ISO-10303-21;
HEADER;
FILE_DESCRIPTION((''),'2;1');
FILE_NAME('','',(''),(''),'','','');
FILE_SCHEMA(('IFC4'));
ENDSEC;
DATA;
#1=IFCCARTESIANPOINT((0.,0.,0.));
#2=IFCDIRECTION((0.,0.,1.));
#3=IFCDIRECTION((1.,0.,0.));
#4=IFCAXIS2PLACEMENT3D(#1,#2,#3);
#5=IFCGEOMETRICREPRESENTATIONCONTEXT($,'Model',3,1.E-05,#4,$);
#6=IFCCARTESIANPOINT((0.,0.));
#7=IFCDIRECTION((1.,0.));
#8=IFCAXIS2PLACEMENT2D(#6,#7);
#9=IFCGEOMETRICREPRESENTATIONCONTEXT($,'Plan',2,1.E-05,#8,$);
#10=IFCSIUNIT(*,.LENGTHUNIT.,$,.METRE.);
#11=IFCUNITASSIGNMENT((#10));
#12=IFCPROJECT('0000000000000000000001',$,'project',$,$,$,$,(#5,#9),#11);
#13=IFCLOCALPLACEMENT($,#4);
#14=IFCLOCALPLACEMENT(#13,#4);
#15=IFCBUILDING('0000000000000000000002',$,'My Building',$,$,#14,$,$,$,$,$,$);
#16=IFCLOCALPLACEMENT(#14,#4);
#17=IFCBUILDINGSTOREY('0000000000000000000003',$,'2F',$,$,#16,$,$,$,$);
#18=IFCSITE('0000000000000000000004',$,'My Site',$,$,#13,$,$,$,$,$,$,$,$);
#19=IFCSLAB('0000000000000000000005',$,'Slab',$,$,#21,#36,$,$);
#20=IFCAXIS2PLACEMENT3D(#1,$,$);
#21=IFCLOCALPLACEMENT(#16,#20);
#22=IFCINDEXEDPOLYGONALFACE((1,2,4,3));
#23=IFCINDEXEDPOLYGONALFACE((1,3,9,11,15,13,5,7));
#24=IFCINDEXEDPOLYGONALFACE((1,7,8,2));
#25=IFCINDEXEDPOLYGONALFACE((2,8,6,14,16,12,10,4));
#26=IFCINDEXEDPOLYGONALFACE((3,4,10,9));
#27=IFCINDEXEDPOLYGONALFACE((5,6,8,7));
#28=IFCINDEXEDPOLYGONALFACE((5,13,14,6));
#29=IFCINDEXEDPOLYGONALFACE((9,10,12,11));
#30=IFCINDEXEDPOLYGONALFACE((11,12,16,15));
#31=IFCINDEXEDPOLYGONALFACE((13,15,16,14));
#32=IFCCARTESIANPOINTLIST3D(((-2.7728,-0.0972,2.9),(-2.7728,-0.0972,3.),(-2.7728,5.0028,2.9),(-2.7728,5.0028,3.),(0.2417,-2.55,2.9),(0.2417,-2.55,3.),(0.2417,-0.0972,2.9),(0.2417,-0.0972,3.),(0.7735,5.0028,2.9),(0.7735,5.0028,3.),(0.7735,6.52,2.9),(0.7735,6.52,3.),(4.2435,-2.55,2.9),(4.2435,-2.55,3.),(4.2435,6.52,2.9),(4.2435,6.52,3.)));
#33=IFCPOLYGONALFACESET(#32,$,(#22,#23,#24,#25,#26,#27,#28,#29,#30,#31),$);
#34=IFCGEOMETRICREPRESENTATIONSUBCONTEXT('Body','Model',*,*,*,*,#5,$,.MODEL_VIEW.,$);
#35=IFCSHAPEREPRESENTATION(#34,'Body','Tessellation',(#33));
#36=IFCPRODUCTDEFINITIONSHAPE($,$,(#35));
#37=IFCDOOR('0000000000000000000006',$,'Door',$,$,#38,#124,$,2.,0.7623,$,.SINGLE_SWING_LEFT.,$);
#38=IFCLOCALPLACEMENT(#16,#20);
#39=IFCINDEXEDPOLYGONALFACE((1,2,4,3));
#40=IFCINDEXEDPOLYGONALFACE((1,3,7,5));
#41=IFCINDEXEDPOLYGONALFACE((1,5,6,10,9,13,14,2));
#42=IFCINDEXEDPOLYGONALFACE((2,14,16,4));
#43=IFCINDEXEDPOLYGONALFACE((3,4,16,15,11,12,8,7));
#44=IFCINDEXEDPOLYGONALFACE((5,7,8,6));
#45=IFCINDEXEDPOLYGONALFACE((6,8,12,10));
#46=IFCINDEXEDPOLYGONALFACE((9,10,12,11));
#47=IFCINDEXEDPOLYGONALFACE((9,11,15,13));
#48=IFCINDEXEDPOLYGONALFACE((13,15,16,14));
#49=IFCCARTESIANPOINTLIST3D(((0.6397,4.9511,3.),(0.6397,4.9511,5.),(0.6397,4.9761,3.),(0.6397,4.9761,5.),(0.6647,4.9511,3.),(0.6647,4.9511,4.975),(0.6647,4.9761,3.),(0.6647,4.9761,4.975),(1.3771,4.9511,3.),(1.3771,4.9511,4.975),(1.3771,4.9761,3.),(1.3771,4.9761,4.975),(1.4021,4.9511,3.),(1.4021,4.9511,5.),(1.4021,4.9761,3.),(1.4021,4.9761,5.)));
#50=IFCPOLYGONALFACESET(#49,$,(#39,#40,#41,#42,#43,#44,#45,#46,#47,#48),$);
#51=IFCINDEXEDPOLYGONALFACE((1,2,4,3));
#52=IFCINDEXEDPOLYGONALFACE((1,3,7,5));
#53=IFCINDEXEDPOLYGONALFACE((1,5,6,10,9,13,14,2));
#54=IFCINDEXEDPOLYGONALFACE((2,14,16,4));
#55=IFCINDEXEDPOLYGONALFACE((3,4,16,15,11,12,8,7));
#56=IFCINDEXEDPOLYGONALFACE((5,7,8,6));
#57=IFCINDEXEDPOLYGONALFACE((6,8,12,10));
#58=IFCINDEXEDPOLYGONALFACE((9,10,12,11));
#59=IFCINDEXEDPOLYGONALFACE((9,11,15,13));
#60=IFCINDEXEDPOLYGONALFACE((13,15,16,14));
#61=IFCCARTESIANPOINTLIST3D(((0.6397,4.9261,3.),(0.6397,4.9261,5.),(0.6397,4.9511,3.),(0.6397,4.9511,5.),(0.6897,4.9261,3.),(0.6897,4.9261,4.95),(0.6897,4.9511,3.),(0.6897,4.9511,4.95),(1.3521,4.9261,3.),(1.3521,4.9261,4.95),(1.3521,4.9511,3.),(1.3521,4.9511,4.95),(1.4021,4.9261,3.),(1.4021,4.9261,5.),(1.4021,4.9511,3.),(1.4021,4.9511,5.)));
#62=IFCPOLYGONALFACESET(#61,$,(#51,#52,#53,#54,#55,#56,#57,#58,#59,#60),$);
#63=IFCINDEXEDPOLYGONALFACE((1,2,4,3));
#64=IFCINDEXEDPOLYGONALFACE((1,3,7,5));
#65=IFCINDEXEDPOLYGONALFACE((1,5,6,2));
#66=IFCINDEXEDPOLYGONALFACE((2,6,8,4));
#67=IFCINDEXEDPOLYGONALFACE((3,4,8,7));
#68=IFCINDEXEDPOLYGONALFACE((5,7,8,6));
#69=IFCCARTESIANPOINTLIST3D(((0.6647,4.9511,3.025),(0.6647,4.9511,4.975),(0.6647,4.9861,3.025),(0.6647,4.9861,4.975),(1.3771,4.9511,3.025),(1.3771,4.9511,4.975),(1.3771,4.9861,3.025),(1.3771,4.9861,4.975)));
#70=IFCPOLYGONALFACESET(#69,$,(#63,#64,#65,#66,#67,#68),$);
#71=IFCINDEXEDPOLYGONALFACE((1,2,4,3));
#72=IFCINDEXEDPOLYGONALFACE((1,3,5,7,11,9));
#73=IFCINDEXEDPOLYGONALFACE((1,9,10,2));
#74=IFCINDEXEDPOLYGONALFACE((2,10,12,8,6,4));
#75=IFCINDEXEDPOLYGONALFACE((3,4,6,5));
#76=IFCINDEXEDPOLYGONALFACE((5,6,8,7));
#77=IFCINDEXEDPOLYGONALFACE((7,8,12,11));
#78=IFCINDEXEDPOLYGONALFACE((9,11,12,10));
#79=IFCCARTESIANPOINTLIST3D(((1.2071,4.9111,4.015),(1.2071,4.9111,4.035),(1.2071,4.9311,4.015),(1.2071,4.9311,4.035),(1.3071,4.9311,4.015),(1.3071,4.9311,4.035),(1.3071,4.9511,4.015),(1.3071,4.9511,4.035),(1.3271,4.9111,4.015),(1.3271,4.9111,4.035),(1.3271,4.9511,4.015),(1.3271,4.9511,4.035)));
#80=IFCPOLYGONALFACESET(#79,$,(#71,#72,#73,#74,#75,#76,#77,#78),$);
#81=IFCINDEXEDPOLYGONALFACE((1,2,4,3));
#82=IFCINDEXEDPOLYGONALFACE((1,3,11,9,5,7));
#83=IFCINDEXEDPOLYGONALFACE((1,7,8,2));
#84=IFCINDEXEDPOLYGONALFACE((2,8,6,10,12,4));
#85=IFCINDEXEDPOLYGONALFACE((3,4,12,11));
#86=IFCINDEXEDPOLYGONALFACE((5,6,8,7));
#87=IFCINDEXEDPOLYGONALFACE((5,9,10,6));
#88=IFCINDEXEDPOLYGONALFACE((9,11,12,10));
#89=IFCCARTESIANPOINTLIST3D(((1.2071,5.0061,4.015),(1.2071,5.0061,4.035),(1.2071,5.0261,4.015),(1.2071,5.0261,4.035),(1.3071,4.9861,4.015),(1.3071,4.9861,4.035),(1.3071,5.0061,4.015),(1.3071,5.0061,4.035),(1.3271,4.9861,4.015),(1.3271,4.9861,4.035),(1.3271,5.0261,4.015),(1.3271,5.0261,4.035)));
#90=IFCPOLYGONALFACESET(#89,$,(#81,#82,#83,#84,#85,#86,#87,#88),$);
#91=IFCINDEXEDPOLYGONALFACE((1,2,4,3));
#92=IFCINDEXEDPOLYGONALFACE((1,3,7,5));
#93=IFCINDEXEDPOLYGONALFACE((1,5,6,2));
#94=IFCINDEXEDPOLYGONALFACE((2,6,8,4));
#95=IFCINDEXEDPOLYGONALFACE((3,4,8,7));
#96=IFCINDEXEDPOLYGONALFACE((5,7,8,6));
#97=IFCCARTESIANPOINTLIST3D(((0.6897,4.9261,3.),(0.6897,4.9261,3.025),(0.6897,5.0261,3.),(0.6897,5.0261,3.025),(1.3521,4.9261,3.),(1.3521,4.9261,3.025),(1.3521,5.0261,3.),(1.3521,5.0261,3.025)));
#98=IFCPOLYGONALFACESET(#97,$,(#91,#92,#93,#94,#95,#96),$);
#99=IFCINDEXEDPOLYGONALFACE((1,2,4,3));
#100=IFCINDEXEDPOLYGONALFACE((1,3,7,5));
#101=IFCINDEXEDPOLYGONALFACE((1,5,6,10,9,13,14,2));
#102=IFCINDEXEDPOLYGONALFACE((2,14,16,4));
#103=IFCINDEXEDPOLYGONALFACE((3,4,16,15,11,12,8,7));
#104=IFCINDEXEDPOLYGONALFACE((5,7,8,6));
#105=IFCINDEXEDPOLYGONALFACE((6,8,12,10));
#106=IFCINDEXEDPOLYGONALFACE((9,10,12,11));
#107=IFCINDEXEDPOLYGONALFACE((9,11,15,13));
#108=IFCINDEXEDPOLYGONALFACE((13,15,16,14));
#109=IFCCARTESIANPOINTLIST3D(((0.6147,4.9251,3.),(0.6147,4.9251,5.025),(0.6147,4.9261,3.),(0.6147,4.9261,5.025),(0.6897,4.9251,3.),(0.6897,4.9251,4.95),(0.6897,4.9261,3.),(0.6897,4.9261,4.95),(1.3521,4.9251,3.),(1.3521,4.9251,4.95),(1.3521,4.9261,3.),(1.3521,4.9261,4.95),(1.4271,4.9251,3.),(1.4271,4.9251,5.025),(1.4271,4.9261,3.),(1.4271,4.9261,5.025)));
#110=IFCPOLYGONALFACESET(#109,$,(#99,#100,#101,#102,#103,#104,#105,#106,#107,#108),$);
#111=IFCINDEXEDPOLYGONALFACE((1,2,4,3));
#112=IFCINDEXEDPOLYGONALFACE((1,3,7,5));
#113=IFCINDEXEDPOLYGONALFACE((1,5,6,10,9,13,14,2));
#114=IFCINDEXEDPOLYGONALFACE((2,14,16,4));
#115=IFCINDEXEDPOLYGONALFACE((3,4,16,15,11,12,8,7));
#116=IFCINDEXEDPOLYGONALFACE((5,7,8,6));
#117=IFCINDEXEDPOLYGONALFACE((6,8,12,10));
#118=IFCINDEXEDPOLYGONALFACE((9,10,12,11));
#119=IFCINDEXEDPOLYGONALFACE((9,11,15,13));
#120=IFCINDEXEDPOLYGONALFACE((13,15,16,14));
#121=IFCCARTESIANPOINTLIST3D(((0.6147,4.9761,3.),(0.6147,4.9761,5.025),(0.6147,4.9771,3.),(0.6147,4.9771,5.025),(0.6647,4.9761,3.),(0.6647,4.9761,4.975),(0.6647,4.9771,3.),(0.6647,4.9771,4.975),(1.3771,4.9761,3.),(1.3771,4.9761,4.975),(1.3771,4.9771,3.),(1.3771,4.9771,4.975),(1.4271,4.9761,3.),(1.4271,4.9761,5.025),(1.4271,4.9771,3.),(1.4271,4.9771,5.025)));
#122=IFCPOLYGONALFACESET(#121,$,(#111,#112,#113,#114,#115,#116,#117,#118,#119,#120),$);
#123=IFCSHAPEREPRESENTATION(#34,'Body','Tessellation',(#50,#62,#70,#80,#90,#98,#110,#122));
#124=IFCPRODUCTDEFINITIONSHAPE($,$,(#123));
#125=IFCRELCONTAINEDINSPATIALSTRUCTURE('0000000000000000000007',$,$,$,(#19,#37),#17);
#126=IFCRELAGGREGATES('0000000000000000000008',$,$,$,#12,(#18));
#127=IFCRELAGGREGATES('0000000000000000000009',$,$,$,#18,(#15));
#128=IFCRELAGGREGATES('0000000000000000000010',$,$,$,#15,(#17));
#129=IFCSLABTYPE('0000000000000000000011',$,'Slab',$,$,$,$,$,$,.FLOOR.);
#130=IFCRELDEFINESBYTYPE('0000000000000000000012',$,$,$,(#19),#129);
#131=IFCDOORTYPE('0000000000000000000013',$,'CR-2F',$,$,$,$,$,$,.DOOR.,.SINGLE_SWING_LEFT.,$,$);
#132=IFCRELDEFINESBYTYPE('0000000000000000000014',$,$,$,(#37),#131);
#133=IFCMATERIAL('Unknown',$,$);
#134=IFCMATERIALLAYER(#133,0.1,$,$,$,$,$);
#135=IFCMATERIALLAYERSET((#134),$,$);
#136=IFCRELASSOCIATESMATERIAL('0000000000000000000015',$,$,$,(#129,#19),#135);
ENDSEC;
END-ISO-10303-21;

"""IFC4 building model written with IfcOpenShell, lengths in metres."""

from ifc_helpers import new_model, entity, si_unit, frame, origin_with_axes, origin_2d_with_axis, place, context, subcontext, project, spatial, line, indexed_curve, outline, extrude, shape, source, transform, mapped, material, layer, layer_set, layer_usage, type_object, type_shapes, element, save


model = new_model("IFC4")

# Units and contexts
model_context = context("Model", 3, precision=1e-05, world=origin_with_axes())
plan_context = context("Plan", 2, precision=1e-05, world=origin_2d_with_axis())
body_context_1 = subcontext(model_context, "Body", "Model", "MODEL_VIEW")
body_context_2 = subcontext(plan_context, "Body", "Plan", "PLAN_VIEW")
ifc_project = project(units=[si_unit("LENGTHUNIT", "METRE")], contexts=[model_context, plan_context])

# Site, building, storey
site_placement = place(None, origin_with_axes())
site = spatial("IfcSite", under=ifc_project, at=site_placement, Name="My Site")
building_placement = place(site_placement, origin_with_axes())
building = spatial("IfcBuilding", under=site, at=building_placement, Name="My Building")
storey_placement = place(building_placement, origin_with_axes())
storey = spatial("IfcBuildingStorey", under=building, at=storey_placement, Name="2F")

# Slab
ifc_material = material(Name="Unknown")
ifc_layer = layer(ifc_material, 0.1)
ifc_layer_set = layer_set([ifc_layer])
ifc_layer_usage = layer_usage(ifc_layer_set, "AXIS3", "POSITIVE", -0.1)
slab_type = type_object("IfcSlabType", Name="Slab", PredefinedType="FLOOR", material=ifc_layer_set)
slab_placement = place(storey_placement, frame((4.2435, -2.55, 3.0), z_axis=(0.0, 0.0, 1.0), x_axis=(1.0, 0.0, 0.0)))
element("IfcSlab", 1, at=slab_placement, inside=storey, type_object=slab_type, material=ifc_layer_usage, Name="Slab", context=body_context_1, shape_type="SweptSolid", body=[
    extrude(outline(indexed_curve([(0.0, 0.0), (0.0, 9.07), (-3.47, 9.07), (-3.47, 7.5528), (-7.0163, 7.5528), (-7.0163, 2.4528), (-4.0018, 2.4528), (-4.0018, 0.0), (0.0, 0.0)])), frame((0.0, 0.0, -0.1), z_axis=(0.0, 0.0, 1.0), x_axis=(1.0, 0.0, 0.0)), (0.0, 0.0, 1.0), 0.1),
])

# Door
door_type_1 = type_object("IfcDoorType", Name="CR-2F", OperationType="SINGLE_SWING_LEFT", PredefinedType="DOOR")
shared_shape_1 = source(origin_with_axes(), body_context_1, "Body", "SweptSolid", [
    extrude(outline(indexed_curve([(0.0, 0.0), (0.0, 2.0), (0.7623, 2.0), (0.7623, 0.0), (0.7373, 0.0), (0.7373, 1.975), (0.025, 1.975), (0.025, 0.0)], segments=[line(1, 2, 3, 4, 5, 6, 7, 8, 1)])), frame((0.0, 0.025, 0.0), z_axis=(0.0, -1.0, 0.0), x_axis=(1.0, 0.0, 0.0)), (0.0, 0.0, -1.0), 0.025),
    extrude(outline(indexed_curve([(0.0, 0.0), (0.0, 2.0), (0.7623, 2.0), (0.7623, 0.0), (0.7123, 0.0), (0.7123, 1.95), (0.05, 1.95), (0.05, 0.0)], segments=[line(1, 2, 3, 4, 5, 6, 7, 8, 1)])), frame((0.0, 0.0, 0.0), z_axis=(0.0, -1.0, 0.0), x_axis=(1.0, 0.0, 0.0)), (0.0, 0.0, -1.0), 0.025),
    extrude(outline(indexed_curve([(0.0, 0.0), (0.7123, 0.0), (0.7123, 0.035), (0.0, 0.035)], segments=[line(1, 2, 3, 4, 1)])), frame((0.025, 0.025, 0.025), z_axis=(0.0, 0.0, 1.0), x_axis=(1.0, 0.0, 0.0)), (0.0, 0.0, 1.0), 1.95),
    extrude(outline(indexed_curve([(0.0, 0.0), (0.0, -0.04), (-0.12, -0.04), (-0.12, -0.02), (-0.02, -0.02), (-0.02, 0.0)], segments=[line(1, 2, 3, 4, 5, 6, 1)])), frame((0.6873, 0.025, 1.015), z_axis=(0.0, 0.0, 1.0), x_axis=(1.0, 0.0, 0.0)), (0.0, 0.0, 1.0), 0.02),
    extrude(outline(indexed_curve([(0.0, 0.0), (0.0, 0.04), (-0.12, 0.04), (-0.12, 0.02), (-0.02, 0.02), (-0.02, 0.0)], segments=[line(1, 2, 3, 4, 5, 6, 1)])), frame((0.6873, 0.06, 1.015), z_axis=(0.0, 0.0, 1.0), x_axis=(1.0, 0.0, 0.0)), (0.0, 0.0, 1.0), 0.02),
    extrude(outline(indexed_curve([(0.0, 0.0), (0.6623, 0.0), (0.6623, 0.1), (0.0, 0.1)], segments=[line(1, 2, 3, 4, 1)])), frame((0.05, 0.0, 0.0), z_axis=(0.0, 0.0, 1.0), x_axis=(1.0, 0.0, 0.0)), (0.0, 0.0, 1.0), 0.025),
    extrude(outline(indexed_curve([(0.0, 0.0), (0.0, 2.025), (0.8123, 2.025), (0.8123, 0.0), (0.7373, 0.0), (0.7373, 1.95), (0.075, 1.95), (0.075, 0.0)], segments=[line(1, 2, 3, 4, 5, 6, 7, 8, 1)])), frame((-0.025, -0.001, 0.0), z_axis=(0.0, -1.0, 0.0), x_axis=(1.0, 0.0, 0.0)), (0.0, 0.0, -1.0), 0.001),
    extrude(outline(indexed_curve([(0.0, 0.0), (0.0, 2.025), (0.8123, 2.025), (0.8123, 0.0), (0.7623, 0.0), (0.7623, 1.975), (0.05, 1.975), (0.05, 0.0)], segments=[line(1, 2, 3, 4, 5, 6, 7, 8, 1)])), frame((-0.025, 0.05, 0.0), z_axis=(0.0, -1.0, 0.0), x_axis=(1.0, 0.0, 0.0)), (0.0, 0.0, -1.0), 0.001),
])
shared_shape_2 = source(origin_with_axes(), body_context_2, "Body", "Curve2D", [
    entity("IfcIndexedPolyCurve", entity("IfcCartesianPointList2D", [[0.0, 0.0], [0.0, 0.05], [0.025, 0.05], [0.025, 0.025], [0.05, 0.025], [0.05, 0.0]]), [entity("IfcLineIndex", [1, 2, 3, 4, 5, 6, 1])]),
    entity("IfcIndexedPolyCurve", entity("IfcCartesianPointList2D", [[0.7623, 0.0], [0.7623, 0.05], [0.7373, 0.05], [0.7373, 0.025], [0.7123, 0.025], [0.7123, 0.0]]), [entity("IfcLineIndex", [1, 2, 3, 4, 5, 6, 1])]),
    entity("IfcTrimmedCurve", entity("IfcEllipse", entity("IfcAxis2Placement2D", entity("IfcCartesianPoint", [0.06, 0.05]), entity("IfcDirection", [1.0, 0.0])), 0.6773, 0.7123), [entity("IfcCartesianPoint", [0.7373, 0.05])], [entity("IfcCartesianPoint", [0.06, 0.7623])], True, "CARTESIAN"),
    entity("IfcIndexedPolyCurve", entity("IfcCartesianPointList2D", [[0.025, 0.05], [0.06, 0.05], [0.06, 0.7623], [0.025, 0.7623]]), [entity("IfcLineIndex", [1, 2, 3, 4, 1])]),
])
type_shapes(door_type_1, [shared_shape_1, shared_shape_2])
placement_1 = place(storey_placement, frame((4.1494, 5.0261, 3.0), z_axis=(0.0, 0.0, 1.0), x_axis=(-1.0, 0.0, 0.0)))
placement_2 = place(placement_1, frame((3.5097, 0.1, 0.0), z_axis=(0.0, 0.0, 1.0), x_axis=(-1.0, 0.0, 0.0)))
door_1_placement = place(placement_2, frame((0.0, 0.0, 0.0), z_axis=(0.0, 0.0, 1.0), x_axis=(1.0, 0.0, 0.0)))
element("IfcDoor", 2, at=door_1_placement, inside=storey, type_object=door_type_1, Name="Door", OperationType="SINGLE_SWING_LEFT", OverallHeight=2.0, OverallWidth=0.7623, shapes=[
    shape(body_context_1, "Body", "MappedRepresentation", [mapped(shared_shape_1, transform((0.0, 0.0, 0.0), x_axis=(1.0, 0.0, 0.0), y_axis=(0.0, 1.0, 0.0), z_axis=(0.0, 0.0, 1.0), scale=1.0))]),
    shape(body_context_2, "Body", "MappedRepresentation", [mapped(shared_shape_2, transform((0.0, 0.0, 0.0), x_axis=(1.0, 0.0, 0.0), y_axis=(0.0, 1.0, 0.0), z_axis=(0.0, 0.0, 1.0), scale=1.0))]),
])

save(model, "model.ifc")
